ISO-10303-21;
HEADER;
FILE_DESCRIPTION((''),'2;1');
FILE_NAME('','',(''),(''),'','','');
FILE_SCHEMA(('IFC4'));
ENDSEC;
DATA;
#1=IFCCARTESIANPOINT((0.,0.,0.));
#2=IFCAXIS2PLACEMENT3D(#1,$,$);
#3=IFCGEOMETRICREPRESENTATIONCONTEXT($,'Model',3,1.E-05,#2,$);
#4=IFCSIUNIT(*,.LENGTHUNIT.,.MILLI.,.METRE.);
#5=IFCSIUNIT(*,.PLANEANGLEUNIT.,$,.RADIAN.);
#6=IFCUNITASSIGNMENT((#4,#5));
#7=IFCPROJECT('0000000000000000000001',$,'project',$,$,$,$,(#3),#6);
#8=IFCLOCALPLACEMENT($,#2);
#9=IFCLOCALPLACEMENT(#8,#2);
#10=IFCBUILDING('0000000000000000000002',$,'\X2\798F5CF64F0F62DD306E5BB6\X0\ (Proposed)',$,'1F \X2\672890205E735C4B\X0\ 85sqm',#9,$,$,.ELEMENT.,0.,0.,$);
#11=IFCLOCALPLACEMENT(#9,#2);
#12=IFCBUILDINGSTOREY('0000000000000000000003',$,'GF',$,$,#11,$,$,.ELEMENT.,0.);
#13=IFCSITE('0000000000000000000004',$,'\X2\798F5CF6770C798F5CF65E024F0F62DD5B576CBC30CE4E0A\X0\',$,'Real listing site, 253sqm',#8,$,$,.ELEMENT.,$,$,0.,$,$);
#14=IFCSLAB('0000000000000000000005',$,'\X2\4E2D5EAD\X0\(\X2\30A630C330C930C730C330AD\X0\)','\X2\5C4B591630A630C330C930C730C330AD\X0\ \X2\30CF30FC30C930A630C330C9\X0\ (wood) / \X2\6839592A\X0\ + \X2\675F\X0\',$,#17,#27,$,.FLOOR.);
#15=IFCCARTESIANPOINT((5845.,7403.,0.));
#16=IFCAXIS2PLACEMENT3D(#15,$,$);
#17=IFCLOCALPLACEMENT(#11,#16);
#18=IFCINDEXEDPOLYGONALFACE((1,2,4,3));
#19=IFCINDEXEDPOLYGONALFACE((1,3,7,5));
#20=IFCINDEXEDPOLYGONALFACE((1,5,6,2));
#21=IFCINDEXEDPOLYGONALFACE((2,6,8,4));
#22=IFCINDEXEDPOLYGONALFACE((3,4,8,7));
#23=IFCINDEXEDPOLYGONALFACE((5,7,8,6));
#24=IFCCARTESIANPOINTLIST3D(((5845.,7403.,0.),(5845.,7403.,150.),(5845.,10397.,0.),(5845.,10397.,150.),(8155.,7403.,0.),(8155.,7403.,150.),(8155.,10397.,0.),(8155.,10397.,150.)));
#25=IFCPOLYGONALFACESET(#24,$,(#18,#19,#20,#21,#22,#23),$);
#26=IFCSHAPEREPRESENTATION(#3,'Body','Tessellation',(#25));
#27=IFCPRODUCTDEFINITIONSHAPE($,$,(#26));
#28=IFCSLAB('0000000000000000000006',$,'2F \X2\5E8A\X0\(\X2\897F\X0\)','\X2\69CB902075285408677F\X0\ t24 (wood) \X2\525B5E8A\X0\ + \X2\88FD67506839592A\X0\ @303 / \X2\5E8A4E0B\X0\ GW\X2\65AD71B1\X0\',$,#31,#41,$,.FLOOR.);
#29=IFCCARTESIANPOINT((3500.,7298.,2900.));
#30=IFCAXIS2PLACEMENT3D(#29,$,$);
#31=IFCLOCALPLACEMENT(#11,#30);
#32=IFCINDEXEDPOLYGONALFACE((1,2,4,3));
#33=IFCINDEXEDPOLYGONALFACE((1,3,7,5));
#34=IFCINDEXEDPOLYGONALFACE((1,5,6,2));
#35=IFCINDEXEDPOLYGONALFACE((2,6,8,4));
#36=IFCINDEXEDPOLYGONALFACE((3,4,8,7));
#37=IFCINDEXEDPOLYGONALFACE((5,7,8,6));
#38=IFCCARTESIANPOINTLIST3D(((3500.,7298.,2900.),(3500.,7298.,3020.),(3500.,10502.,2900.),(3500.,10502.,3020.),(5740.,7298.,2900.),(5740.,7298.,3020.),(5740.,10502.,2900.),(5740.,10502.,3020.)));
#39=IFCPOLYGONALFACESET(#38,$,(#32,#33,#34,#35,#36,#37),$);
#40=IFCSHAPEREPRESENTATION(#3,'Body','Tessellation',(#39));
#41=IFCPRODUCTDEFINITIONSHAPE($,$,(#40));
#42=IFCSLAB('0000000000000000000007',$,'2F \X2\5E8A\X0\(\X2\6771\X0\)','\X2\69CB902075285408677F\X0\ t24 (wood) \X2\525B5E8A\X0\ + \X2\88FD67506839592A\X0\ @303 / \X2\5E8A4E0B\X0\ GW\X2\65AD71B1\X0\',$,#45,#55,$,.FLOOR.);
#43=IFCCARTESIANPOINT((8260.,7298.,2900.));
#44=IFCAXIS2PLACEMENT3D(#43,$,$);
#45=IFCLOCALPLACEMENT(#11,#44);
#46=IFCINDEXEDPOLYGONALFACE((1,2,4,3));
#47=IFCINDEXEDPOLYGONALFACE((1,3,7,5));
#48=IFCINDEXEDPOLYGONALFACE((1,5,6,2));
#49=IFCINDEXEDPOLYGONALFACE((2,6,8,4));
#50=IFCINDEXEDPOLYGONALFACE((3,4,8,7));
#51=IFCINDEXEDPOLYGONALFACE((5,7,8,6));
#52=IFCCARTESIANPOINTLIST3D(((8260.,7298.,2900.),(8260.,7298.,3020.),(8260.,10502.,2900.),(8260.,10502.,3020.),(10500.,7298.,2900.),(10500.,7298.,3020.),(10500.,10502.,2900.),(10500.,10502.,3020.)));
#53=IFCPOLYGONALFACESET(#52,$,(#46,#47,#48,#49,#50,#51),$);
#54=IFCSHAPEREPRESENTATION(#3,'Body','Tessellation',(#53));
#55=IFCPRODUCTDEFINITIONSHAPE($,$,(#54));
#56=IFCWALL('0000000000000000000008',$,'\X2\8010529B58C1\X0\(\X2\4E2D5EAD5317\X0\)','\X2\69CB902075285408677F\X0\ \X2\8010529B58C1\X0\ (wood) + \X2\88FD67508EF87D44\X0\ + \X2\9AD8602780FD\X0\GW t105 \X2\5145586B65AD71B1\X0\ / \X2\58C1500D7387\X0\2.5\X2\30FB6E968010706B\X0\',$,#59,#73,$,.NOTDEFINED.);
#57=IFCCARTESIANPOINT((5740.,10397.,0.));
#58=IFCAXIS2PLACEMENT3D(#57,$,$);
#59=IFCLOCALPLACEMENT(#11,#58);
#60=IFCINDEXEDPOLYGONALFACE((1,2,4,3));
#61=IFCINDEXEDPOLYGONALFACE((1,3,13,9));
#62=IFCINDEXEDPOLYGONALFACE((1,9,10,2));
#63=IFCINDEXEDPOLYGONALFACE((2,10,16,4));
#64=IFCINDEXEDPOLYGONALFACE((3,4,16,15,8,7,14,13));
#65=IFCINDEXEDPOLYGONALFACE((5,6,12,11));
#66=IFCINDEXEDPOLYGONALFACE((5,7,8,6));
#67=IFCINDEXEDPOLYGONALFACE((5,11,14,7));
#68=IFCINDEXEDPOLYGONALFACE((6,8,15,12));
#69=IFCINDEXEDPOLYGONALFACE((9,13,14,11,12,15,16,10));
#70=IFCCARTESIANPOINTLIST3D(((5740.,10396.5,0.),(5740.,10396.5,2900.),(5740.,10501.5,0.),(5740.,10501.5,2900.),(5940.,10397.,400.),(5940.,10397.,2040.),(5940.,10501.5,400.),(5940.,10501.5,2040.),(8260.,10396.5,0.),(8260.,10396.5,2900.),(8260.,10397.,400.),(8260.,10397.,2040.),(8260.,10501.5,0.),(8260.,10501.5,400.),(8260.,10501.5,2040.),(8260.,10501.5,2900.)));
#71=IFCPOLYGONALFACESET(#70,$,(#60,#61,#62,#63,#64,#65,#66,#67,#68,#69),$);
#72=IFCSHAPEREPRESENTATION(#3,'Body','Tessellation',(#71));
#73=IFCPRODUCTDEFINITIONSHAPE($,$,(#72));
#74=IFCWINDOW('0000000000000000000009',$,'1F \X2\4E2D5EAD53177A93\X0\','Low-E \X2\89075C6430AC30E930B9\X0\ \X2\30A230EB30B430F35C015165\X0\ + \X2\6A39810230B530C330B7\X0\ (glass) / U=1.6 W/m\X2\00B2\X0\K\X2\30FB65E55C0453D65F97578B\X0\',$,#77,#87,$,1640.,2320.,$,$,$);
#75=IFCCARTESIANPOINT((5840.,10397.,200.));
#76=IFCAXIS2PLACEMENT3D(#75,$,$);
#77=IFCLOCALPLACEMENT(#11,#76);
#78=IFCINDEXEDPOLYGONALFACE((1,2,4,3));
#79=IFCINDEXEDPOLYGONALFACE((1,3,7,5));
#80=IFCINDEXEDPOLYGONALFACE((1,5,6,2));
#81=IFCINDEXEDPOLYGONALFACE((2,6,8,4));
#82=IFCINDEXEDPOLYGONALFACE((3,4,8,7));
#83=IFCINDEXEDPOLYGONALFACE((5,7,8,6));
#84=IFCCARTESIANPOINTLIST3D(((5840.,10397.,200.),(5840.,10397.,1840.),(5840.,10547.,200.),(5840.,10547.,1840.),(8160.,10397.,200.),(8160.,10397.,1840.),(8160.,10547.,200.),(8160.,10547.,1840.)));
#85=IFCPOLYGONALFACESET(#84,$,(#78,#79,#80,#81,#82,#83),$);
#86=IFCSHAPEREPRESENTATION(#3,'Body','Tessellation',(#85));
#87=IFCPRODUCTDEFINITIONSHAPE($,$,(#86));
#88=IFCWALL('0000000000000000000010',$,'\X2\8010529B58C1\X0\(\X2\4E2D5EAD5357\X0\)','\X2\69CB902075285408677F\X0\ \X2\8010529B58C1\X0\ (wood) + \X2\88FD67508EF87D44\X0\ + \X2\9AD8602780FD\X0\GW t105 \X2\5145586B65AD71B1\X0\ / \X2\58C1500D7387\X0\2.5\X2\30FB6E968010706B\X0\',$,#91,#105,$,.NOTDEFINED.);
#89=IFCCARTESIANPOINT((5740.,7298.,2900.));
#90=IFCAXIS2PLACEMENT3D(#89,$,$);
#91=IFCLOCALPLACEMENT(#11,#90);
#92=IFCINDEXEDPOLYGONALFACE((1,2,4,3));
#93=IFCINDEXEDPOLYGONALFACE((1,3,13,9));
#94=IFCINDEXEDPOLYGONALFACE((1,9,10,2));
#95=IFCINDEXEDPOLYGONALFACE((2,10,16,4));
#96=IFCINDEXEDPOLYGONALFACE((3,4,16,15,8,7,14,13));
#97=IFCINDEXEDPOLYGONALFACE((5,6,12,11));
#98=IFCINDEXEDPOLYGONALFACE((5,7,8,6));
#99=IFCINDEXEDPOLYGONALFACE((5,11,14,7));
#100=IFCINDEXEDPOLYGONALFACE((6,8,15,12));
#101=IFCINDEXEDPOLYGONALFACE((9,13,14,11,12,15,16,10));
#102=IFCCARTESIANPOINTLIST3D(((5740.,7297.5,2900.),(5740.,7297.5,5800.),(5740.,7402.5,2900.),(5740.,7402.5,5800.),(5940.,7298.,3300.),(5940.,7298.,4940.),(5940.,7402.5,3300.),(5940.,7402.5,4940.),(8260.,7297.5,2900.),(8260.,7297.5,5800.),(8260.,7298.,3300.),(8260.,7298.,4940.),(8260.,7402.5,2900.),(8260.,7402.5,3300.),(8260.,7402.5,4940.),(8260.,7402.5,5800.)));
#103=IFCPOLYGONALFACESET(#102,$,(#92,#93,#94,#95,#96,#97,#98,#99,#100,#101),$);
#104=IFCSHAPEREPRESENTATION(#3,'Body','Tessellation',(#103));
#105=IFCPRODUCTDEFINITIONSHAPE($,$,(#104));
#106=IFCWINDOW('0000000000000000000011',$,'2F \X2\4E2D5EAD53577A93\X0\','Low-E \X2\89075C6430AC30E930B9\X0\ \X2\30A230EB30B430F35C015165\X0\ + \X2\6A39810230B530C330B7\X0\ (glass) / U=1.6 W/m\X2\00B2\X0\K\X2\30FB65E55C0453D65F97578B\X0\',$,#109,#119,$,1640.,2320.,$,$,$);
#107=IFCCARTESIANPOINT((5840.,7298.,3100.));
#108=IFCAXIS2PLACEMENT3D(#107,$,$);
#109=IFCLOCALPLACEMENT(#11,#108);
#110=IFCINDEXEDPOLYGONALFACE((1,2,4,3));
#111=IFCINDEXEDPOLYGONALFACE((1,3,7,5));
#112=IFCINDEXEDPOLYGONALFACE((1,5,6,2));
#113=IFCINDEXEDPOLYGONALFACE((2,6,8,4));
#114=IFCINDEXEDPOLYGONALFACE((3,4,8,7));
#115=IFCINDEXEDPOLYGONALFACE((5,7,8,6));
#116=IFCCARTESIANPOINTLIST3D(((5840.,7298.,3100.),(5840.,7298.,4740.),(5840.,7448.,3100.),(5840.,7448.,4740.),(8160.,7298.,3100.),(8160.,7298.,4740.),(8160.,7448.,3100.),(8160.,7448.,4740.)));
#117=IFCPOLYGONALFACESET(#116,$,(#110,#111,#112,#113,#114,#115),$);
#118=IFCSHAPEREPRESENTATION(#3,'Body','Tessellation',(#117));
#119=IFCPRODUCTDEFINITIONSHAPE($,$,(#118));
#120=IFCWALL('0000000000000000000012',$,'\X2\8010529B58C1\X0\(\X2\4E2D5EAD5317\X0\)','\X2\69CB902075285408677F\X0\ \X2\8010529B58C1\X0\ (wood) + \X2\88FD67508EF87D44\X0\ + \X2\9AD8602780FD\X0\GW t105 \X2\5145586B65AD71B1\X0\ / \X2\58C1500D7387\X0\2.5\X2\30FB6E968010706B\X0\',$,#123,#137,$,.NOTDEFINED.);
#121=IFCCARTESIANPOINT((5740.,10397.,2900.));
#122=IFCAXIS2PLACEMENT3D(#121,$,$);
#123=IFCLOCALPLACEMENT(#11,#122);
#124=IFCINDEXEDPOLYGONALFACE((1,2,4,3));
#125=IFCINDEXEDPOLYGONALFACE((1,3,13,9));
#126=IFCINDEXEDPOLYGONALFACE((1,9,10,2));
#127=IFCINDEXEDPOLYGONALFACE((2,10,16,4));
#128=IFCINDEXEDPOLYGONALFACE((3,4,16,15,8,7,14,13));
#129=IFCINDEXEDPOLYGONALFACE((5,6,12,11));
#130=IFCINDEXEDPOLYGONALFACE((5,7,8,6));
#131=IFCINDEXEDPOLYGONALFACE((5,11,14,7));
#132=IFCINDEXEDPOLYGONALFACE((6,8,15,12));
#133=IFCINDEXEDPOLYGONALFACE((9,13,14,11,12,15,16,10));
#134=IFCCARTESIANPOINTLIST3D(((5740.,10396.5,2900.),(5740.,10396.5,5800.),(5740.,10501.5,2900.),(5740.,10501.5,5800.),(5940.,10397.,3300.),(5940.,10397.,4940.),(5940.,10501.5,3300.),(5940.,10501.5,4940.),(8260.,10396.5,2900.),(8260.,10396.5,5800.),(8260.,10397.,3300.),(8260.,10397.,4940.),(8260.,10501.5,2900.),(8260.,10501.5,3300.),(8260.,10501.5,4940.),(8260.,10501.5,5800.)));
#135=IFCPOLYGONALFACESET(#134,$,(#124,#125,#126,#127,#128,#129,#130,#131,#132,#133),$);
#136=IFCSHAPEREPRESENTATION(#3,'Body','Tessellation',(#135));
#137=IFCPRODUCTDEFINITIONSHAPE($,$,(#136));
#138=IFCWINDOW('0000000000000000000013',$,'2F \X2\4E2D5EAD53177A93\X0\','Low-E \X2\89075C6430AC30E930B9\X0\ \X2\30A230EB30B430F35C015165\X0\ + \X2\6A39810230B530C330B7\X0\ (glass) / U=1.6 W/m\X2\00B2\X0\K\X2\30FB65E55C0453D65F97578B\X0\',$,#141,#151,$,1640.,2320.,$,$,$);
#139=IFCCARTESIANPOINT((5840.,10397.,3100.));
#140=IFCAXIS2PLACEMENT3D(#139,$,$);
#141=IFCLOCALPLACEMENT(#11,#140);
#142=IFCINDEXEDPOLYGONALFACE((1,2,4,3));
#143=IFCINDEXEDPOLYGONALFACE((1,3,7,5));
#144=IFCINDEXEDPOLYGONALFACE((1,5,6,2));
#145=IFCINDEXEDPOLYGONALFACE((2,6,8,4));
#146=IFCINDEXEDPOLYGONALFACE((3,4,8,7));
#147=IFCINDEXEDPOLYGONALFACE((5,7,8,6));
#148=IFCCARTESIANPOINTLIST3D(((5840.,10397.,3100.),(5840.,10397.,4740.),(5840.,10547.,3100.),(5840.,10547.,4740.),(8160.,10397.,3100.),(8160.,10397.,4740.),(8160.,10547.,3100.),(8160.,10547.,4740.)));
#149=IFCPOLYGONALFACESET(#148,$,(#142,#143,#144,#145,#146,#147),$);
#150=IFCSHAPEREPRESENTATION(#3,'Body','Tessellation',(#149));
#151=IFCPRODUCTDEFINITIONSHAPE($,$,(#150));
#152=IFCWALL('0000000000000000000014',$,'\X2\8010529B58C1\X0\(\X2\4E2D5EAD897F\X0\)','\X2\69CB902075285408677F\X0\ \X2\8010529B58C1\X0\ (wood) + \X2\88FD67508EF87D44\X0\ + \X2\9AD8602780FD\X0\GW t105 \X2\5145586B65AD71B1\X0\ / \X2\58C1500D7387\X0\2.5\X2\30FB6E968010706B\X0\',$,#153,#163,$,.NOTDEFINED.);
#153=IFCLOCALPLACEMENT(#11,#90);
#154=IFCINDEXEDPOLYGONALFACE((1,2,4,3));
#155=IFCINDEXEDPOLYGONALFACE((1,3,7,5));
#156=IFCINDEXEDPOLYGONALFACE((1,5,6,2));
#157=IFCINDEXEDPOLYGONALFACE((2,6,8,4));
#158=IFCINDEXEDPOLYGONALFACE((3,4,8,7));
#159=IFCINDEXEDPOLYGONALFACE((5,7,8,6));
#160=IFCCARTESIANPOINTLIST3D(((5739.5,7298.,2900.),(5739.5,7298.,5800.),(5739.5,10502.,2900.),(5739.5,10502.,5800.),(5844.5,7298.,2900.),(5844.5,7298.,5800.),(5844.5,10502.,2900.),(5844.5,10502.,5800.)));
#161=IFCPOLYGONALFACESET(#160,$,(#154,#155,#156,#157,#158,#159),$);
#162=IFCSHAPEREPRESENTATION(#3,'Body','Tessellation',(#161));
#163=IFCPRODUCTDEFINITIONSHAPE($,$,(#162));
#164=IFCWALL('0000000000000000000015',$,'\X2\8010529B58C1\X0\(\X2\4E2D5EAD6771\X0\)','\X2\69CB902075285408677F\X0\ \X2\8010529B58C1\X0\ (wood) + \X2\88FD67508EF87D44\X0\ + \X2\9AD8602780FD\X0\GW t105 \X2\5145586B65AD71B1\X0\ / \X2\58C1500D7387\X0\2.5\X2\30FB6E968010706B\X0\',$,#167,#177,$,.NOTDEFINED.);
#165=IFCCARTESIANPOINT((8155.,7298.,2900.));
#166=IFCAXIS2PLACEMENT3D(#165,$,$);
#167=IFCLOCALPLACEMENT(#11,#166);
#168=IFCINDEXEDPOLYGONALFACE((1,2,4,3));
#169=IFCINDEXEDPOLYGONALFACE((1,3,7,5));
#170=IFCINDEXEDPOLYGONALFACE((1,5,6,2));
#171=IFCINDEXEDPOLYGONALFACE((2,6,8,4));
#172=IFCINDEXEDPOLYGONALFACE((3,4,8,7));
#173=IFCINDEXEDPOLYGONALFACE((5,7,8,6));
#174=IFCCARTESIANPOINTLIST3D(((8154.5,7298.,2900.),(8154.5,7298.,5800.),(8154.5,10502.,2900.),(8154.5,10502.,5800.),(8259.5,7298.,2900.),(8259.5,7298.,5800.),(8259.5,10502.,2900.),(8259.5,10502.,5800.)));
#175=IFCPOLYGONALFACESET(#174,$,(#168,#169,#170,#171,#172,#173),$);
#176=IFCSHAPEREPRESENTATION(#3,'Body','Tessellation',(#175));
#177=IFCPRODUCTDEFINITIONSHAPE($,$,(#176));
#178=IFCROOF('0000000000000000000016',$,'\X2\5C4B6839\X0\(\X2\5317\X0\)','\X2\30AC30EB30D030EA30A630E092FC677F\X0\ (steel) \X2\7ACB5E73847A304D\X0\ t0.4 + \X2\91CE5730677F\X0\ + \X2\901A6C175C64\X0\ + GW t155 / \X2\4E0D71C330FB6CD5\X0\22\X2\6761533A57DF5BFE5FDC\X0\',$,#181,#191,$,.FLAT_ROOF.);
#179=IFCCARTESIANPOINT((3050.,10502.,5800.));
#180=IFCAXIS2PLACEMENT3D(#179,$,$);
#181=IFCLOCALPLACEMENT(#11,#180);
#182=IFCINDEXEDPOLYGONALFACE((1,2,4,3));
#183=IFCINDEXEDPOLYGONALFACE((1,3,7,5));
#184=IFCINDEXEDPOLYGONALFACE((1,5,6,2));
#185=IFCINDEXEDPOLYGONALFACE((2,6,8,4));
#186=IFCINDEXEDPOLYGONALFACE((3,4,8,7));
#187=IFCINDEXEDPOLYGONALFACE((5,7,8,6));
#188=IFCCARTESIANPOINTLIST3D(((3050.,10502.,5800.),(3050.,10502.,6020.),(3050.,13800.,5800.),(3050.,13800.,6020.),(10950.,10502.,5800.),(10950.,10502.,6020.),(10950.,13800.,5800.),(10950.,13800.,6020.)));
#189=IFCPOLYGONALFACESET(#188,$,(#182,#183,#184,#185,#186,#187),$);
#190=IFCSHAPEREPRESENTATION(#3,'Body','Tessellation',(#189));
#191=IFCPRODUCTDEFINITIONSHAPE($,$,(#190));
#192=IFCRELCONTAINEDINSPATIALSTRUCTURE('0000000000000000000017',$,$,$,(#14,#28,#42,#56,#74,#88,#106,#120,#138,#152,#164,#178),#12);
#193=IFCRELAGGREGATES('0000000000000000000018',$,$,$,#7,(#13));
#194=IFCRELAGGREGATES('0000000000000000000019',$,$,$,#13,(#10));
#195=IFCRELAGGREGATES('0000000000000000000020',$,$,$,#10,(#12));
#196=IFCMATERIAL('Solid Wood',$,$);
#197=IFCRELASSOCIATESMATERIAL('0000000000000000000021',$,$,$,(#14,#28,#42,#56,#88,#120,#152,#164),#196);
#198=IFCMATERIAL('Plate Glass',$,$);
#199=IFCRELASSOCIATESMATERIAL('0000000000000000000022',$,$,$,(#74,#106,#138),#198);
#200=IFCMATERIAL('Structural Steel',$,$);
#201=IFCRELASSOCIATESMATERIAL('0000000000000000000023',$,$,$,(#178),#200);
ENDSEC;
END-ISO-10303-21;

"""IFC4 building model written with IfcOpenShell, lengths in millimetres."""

from ifc_helpers import new_model, si_unit, frame, frame_2d, origin, place, context, project, spatial, rectangle, extrude, material, element, fill, save


model = new_model("IFC4")

# Units and contexts
model_context = context("Model", 3, precision=1e-05, world=origin())
ifc_project = project(units=[si_unit("LENGTHUNIT", "METRE", prefix="MILLI"), si_unit("PLANEANGLEUNIT", "RADIAN")], contexts=[model_context])

# Site, building, storey
site_placement = place(None, origin())
site = spatial("IfcSite", under=ifc_project, at=site_placement, Name="福島県福島市伏拝字沼ノ上", ObjectType="Real listing site, 253sqm", CompositionType="ELEMENT", RefElevation=0.0)
building_placement = place(site_placement, origin())
building = spatial("IfcBuilding", under=site, at=building_placement, Name="福島伏拝の家 (Proposed)", ObjectType="1F 木造平屋 85sqm", CompositionType="ELEMENT", ElevationOfRefHeight=0.0, ElevationOfTerrain=0.0)
storey_placement = place(building_placement, origin())
storey = spatial("IfcBuildingStorey", under=building, at=storey_placement, Name="GF", CompositionType="ELEMENT", Elevation=0.0)

# Slabs
ifc_material_1 = material(Name="Solid Wood")
slab_1_placement = place(storey_placement, frame((5845.0, 7403.0, 0.0)))
element("IfcSlab", 1, at=slab_1_placement, inside=storey, material=ifc_material_1, Name="中庭(ウッドデッキ)", Description="屋外ウッドデッキ ハードウッド (wood) / 根太 + 束", PredefinedType="FLOOR", context=model_context, shape_type="SweptSolid", body=[
    extrude(rectangle(XDim=2310.0, YDim=2994.0, at=frame_2d((1155.0, 1497.0))), frame((5845.0, 7403.0, 0.0)), (0.0, 0.0, 1.0), 150.0),
])
slab_2_placement = place(storey_placement, frame((3500.0, 7298.0, 2900.0)))
element("IfcSlab", 2, at=slab_2_placement, inside=storey, material=ifc_material_1, Name="2F 床(西)", Description="構造用合板 t24 (wood) 剛床 + 製材根太 @303 / 床下 GW断熱", PredefinedType="FLOOR", context=model_context, shape_type="SweptSolid", body=[
    extrude(rectangle(XDim=2240.0, YDim=3204.0, at=frame_2d((1120.0, 1602.0))), frame((3500.0, 7298.0, 2900.0)), (0.0, 0.0, 1.0), 120.0),
])
slab_3_placement = place(storey_placement, frame((8260.0, 7298.0, 2900.0)))
element("IfcSlab", 3, at=slab_3_placement, inside=storey, material=ifc_material_1, Name="2F 床(東)", Description="構造用合板 t24 (wood) 剛床 + 製材根太 @303 / 床下 GW断熱", PredefinedType="FLOOR", context=model_context, shape_type="SweptSolid", body=[
    extrude(rectangle(XDim=2240.0, YDim=3204.0, at=frame_2d((1120.0, 1602.0))), frame((8260.0, 7298.0, 2900.0)), (0.0, 0.0, 1.0), 120.0),
])

# Walls, openings, windows
wall_1_placement = place(storey_placement, frame((5740.0, 10397.0, 0.0)))
wall_1 = element("IfcWall", 4, at=wall_1_placement, inside=storey, material=ifc_material_1, Name="耐力壁(中庭北)", Description="構造用合板 耐力壁 (wood) + 製材軸組 + 高性能GW t105 充填断熱 / 壁倍率2.5・準耐火", PredefinedType="NOTDEFINED", context=model_context, shape_type="SweptSolid", body=[
    extrude(rectangle(XDim=2520.0, YDim=105.0, at=frame_2d((1260.0, 52.0))), frame((5740.0, 10397.0, 0.0)), (0.0, 0.0, 1.0), 2900.0),
])
opening_1_placement = place(storey_placement, frame((5840.0, 10397.0, 200.0)))
opening_1 = element("IfcOpeningElement", 5, at=opening_1_placement, cuts=wall_1, PredefinedType="NOTDEFINED", context=model_context, shape_type="SweptSolid", body=[
    extrude(rectangle(XDim=2320.0, YDim=150.0, at=frame_2d((1160.0, 75.0))), frame((5840.0, 10397.0, 200.0)), (0.0, 0.0, 1.0), 1640.0),
])
ifc_material_2 = material(Name="Plate Glass")
window_1_placement = place(storey_placement, frame((5840.0, 10397.0, 200.0)))
window_1 = element("IfcWindow", 6, at=window_1_placement, inside=storey, material=ifc_material_2, Name="1F 中庭北窓", Description="Low-E 複層ガラス アルゴン封入 + 樹脂サッシ (glass) / U=1.6 W/m²K・日射取得型", OverallHeight=1640.0, OverallWidth=2320.0, context=model_context, shape_type="SweptSolid", body=[
    extrude(rectangle(XDim=2320.0, YDim=150.0, at=frame_2d((1160.0, 75.0))), frame((5840.0, 10397.0, 200.0)), (0.0, 0.0, 1.0), 1640.0),
])
fill(opening_1, window_1)
wall_2_placement = place(storey_placement, frame((5740.0, 7298.0, 2900.0)))
wall_2 = element("IfcWall", 7, at=wall_2_placement, inside=storey, material=ifc_material_1, Name="耐力壁(中庭南)", Description="構造用合板 耐力壁 (wood) + 製材軸組 + 高性能GW t105 充填断熱 / 壁倍率2.5・準耐火", PredefinedType="NOTDEFINED", context=model_context, shape_type="SweptSolid", body=[
    extrude(rectangle(XDim=2520.0, YDim=105.0, at=frame_2d((1260.0, 52.0))), frame((5740.0, 7298.0, 2900.0)), (0.0, 0.0, 1.0), 2900.0),
])
opening_2_placement = place(storey_placement, frame((5840.0, 7298.0, 3100.0)))
opening_2 = element("IfcOpeningElement", 8, at=opening_2_placement, cuts=wall_2, PredefinedType="NOTDEFINED", context=model_context, shape_type="SweptSolid", body=[
    extrude(rectangle(XDim=2320.0, YDim=150.0, at=frame_2d((1160.0, 75.0))), frame((5840.0, 7298.0, 3100.0)), (0.0, 0.0, 1.0), 1640.0),
])
window_2_placement = place(storey_placement, frame((5840.0, 7298.0, 3100.0)))
window_2 = element("IfcWindow", 9, at=window_2_placement, inside=storey, material=ifc_material_2, Name="2F 中庭南窓", Description="Low-E 複層ガラス アルゴン封入 + 樹脂サッシ (glass) / U=1.6 W/m²K・日射取得型", OverallHeight=1640.0, OverallWidth=2320.0, context=model_context, shape_type="SweptSolid", body=[
    extrude(rectangle(XDim=2320.0, YDim=150.0, at=frame_2d((1160.0, 75.0))), frame((5840.0, 7298.0, 3100.0)), (0.0, 0.0, 1.0), 1640.0),
])
fill(opening_2, window_2)
wall_3_placement = place(storey_placement, frame((5740.0, 10397.0, 2900.0)))
wall_3 = element("IfcWall", 10, at=wall_3_placement, inside=storey, material=ifc_material_1, Name="耐力壁(中庭北)", Description="構造用合板 耐力壁 (wood) + 製材軸組 + 高性能GW t105 充填断熱 / 壁倍率2.5・準耐火", PredefinedType="NOTDEFINED", context=model_context, shape_type="SweptSolid", body=[
    extrude(rectangle(XDim=2520.0, YDim=105.0, at=frame_2d((1260.0, 52.0))), frame((5740.0, 10397.0, 2900.0)), (0.0, 0.0, 1.0), 2900.0),
])
opening_3_placement = place(storey_placement, frame((5840.0, 10397.0, 3100.0)))
opening_3 = element("IfcOpeningElement", 11, at=opening_3_placement, cuts=wall_3, PredefinedType="NOTDEFINED", context=model_context, shape_type="SweptSolid", body=[
    extrude(rectangle(XDim=2320.0, YDim=150.0, at=frame_2d((1160.0, 75.0))), frame((5840.0, 10397.0, 3100.0)), (0.0, 0.0, 1.0), 1640.0),
])
window_3_placement = place(storey_placement, frame((5840.0, 10397.0, 3100.0)))
window_3 = element("IfcWindow", 12, at=window_3_placement, inside=storey, material=ifc_material_2, Name="2F 中庭北窓", Description="Low-E 複層ガラス アルゴン封入 + 樹脂サッシ (glass) / U=1.6 W/m²K・日射取得型", OverallHeight=1640.0, OverallWidth=2320.0, context=model_context, shape_type="SweptSolid", body=[
    extrude(rectangle(XDim=2320.0, YDim=150.0, at=frame_2d((1160.0, 75.0))), frame((5840.0, 10397.0, 3100.0)), (0.0, 0.0, 1.0), 1640.0),
])
fill(opening_3, window_3)

# Walls
wall_4_placement = place(storey_placement, frame((5740.0, 7298.0, 2900.0)))
element("IfcWall", 13, at=wall_4_placement, inside=storey, material=ifc_material_1, Name="耐力壁(中庭西)", Description="構造用合板 耐力壁 (wood) + 製材軸組 + 高性能GW t105 充填断熱 / 壁倍率2.5・準耐火", PredefinedType="NOTDEFINED", context=model_context, shape_type="SweptSolid", body=[
    extrude(rectangle(XDim=105.0, YDim=3204.0, at=frame_2d((52.0, 1602.0))), frame((5740.0, 7298.0, 2900.0)), (0.0, 0.0, 1.0), 2900.0),
])
wall_5_placement = place(storey_placement, frame((8155.0, 7298.0, 2900.0)))
element("IfcWall", 14, at=wall_5_placement, inside=storey, material=ifc_material_1, Name="耐力壁(中庭東)", Description="構造用合板 耐力壁 (wood) + 製材軸組 + 高性能GW t105 充填断熱 / 壁倍率2.5・準耐火", PredefinedType="NOTDEFINED", context=model_context, shape_type="SweptSolid", body=[
    extrude(rectangle(XDim=105.0, YDim=3204.0, at=frame_2d((52.0, 1602.0))), frame((8155.0, 7298.0, 2900.0)), (0.0, 0.0, 1.0), 2900.0),
])

# Roof
ifc_material_3 = material(Name="Structural Steel")
roof_1_placement = place(storey_placement, frame((3050.0, 10502.0, 5800.0)))
element("IfcRoof", 15, at=roof_1_placement, inside=storey, material=ifc_material_3, Name="屋根(北)", Description="ガルバリウム鋼板 (steel) 立平葺き t0.4 + 野地板 + 通気層 + GW t155 / 不燃・法22条区域対応", PredefinedType="FLAT_ROOF", context=model_context, shape_type="SweptSolid", body=[
    extrude(rectangle(XDim=7900.0, YDim=3298.0, at=frame_2d((3950.0, 1649.0))), frame((3050.0, 10502.0, 5800.0)), (0.0, 0.0, 1.0), 220.0),
])

save(model, "model.ifc")
